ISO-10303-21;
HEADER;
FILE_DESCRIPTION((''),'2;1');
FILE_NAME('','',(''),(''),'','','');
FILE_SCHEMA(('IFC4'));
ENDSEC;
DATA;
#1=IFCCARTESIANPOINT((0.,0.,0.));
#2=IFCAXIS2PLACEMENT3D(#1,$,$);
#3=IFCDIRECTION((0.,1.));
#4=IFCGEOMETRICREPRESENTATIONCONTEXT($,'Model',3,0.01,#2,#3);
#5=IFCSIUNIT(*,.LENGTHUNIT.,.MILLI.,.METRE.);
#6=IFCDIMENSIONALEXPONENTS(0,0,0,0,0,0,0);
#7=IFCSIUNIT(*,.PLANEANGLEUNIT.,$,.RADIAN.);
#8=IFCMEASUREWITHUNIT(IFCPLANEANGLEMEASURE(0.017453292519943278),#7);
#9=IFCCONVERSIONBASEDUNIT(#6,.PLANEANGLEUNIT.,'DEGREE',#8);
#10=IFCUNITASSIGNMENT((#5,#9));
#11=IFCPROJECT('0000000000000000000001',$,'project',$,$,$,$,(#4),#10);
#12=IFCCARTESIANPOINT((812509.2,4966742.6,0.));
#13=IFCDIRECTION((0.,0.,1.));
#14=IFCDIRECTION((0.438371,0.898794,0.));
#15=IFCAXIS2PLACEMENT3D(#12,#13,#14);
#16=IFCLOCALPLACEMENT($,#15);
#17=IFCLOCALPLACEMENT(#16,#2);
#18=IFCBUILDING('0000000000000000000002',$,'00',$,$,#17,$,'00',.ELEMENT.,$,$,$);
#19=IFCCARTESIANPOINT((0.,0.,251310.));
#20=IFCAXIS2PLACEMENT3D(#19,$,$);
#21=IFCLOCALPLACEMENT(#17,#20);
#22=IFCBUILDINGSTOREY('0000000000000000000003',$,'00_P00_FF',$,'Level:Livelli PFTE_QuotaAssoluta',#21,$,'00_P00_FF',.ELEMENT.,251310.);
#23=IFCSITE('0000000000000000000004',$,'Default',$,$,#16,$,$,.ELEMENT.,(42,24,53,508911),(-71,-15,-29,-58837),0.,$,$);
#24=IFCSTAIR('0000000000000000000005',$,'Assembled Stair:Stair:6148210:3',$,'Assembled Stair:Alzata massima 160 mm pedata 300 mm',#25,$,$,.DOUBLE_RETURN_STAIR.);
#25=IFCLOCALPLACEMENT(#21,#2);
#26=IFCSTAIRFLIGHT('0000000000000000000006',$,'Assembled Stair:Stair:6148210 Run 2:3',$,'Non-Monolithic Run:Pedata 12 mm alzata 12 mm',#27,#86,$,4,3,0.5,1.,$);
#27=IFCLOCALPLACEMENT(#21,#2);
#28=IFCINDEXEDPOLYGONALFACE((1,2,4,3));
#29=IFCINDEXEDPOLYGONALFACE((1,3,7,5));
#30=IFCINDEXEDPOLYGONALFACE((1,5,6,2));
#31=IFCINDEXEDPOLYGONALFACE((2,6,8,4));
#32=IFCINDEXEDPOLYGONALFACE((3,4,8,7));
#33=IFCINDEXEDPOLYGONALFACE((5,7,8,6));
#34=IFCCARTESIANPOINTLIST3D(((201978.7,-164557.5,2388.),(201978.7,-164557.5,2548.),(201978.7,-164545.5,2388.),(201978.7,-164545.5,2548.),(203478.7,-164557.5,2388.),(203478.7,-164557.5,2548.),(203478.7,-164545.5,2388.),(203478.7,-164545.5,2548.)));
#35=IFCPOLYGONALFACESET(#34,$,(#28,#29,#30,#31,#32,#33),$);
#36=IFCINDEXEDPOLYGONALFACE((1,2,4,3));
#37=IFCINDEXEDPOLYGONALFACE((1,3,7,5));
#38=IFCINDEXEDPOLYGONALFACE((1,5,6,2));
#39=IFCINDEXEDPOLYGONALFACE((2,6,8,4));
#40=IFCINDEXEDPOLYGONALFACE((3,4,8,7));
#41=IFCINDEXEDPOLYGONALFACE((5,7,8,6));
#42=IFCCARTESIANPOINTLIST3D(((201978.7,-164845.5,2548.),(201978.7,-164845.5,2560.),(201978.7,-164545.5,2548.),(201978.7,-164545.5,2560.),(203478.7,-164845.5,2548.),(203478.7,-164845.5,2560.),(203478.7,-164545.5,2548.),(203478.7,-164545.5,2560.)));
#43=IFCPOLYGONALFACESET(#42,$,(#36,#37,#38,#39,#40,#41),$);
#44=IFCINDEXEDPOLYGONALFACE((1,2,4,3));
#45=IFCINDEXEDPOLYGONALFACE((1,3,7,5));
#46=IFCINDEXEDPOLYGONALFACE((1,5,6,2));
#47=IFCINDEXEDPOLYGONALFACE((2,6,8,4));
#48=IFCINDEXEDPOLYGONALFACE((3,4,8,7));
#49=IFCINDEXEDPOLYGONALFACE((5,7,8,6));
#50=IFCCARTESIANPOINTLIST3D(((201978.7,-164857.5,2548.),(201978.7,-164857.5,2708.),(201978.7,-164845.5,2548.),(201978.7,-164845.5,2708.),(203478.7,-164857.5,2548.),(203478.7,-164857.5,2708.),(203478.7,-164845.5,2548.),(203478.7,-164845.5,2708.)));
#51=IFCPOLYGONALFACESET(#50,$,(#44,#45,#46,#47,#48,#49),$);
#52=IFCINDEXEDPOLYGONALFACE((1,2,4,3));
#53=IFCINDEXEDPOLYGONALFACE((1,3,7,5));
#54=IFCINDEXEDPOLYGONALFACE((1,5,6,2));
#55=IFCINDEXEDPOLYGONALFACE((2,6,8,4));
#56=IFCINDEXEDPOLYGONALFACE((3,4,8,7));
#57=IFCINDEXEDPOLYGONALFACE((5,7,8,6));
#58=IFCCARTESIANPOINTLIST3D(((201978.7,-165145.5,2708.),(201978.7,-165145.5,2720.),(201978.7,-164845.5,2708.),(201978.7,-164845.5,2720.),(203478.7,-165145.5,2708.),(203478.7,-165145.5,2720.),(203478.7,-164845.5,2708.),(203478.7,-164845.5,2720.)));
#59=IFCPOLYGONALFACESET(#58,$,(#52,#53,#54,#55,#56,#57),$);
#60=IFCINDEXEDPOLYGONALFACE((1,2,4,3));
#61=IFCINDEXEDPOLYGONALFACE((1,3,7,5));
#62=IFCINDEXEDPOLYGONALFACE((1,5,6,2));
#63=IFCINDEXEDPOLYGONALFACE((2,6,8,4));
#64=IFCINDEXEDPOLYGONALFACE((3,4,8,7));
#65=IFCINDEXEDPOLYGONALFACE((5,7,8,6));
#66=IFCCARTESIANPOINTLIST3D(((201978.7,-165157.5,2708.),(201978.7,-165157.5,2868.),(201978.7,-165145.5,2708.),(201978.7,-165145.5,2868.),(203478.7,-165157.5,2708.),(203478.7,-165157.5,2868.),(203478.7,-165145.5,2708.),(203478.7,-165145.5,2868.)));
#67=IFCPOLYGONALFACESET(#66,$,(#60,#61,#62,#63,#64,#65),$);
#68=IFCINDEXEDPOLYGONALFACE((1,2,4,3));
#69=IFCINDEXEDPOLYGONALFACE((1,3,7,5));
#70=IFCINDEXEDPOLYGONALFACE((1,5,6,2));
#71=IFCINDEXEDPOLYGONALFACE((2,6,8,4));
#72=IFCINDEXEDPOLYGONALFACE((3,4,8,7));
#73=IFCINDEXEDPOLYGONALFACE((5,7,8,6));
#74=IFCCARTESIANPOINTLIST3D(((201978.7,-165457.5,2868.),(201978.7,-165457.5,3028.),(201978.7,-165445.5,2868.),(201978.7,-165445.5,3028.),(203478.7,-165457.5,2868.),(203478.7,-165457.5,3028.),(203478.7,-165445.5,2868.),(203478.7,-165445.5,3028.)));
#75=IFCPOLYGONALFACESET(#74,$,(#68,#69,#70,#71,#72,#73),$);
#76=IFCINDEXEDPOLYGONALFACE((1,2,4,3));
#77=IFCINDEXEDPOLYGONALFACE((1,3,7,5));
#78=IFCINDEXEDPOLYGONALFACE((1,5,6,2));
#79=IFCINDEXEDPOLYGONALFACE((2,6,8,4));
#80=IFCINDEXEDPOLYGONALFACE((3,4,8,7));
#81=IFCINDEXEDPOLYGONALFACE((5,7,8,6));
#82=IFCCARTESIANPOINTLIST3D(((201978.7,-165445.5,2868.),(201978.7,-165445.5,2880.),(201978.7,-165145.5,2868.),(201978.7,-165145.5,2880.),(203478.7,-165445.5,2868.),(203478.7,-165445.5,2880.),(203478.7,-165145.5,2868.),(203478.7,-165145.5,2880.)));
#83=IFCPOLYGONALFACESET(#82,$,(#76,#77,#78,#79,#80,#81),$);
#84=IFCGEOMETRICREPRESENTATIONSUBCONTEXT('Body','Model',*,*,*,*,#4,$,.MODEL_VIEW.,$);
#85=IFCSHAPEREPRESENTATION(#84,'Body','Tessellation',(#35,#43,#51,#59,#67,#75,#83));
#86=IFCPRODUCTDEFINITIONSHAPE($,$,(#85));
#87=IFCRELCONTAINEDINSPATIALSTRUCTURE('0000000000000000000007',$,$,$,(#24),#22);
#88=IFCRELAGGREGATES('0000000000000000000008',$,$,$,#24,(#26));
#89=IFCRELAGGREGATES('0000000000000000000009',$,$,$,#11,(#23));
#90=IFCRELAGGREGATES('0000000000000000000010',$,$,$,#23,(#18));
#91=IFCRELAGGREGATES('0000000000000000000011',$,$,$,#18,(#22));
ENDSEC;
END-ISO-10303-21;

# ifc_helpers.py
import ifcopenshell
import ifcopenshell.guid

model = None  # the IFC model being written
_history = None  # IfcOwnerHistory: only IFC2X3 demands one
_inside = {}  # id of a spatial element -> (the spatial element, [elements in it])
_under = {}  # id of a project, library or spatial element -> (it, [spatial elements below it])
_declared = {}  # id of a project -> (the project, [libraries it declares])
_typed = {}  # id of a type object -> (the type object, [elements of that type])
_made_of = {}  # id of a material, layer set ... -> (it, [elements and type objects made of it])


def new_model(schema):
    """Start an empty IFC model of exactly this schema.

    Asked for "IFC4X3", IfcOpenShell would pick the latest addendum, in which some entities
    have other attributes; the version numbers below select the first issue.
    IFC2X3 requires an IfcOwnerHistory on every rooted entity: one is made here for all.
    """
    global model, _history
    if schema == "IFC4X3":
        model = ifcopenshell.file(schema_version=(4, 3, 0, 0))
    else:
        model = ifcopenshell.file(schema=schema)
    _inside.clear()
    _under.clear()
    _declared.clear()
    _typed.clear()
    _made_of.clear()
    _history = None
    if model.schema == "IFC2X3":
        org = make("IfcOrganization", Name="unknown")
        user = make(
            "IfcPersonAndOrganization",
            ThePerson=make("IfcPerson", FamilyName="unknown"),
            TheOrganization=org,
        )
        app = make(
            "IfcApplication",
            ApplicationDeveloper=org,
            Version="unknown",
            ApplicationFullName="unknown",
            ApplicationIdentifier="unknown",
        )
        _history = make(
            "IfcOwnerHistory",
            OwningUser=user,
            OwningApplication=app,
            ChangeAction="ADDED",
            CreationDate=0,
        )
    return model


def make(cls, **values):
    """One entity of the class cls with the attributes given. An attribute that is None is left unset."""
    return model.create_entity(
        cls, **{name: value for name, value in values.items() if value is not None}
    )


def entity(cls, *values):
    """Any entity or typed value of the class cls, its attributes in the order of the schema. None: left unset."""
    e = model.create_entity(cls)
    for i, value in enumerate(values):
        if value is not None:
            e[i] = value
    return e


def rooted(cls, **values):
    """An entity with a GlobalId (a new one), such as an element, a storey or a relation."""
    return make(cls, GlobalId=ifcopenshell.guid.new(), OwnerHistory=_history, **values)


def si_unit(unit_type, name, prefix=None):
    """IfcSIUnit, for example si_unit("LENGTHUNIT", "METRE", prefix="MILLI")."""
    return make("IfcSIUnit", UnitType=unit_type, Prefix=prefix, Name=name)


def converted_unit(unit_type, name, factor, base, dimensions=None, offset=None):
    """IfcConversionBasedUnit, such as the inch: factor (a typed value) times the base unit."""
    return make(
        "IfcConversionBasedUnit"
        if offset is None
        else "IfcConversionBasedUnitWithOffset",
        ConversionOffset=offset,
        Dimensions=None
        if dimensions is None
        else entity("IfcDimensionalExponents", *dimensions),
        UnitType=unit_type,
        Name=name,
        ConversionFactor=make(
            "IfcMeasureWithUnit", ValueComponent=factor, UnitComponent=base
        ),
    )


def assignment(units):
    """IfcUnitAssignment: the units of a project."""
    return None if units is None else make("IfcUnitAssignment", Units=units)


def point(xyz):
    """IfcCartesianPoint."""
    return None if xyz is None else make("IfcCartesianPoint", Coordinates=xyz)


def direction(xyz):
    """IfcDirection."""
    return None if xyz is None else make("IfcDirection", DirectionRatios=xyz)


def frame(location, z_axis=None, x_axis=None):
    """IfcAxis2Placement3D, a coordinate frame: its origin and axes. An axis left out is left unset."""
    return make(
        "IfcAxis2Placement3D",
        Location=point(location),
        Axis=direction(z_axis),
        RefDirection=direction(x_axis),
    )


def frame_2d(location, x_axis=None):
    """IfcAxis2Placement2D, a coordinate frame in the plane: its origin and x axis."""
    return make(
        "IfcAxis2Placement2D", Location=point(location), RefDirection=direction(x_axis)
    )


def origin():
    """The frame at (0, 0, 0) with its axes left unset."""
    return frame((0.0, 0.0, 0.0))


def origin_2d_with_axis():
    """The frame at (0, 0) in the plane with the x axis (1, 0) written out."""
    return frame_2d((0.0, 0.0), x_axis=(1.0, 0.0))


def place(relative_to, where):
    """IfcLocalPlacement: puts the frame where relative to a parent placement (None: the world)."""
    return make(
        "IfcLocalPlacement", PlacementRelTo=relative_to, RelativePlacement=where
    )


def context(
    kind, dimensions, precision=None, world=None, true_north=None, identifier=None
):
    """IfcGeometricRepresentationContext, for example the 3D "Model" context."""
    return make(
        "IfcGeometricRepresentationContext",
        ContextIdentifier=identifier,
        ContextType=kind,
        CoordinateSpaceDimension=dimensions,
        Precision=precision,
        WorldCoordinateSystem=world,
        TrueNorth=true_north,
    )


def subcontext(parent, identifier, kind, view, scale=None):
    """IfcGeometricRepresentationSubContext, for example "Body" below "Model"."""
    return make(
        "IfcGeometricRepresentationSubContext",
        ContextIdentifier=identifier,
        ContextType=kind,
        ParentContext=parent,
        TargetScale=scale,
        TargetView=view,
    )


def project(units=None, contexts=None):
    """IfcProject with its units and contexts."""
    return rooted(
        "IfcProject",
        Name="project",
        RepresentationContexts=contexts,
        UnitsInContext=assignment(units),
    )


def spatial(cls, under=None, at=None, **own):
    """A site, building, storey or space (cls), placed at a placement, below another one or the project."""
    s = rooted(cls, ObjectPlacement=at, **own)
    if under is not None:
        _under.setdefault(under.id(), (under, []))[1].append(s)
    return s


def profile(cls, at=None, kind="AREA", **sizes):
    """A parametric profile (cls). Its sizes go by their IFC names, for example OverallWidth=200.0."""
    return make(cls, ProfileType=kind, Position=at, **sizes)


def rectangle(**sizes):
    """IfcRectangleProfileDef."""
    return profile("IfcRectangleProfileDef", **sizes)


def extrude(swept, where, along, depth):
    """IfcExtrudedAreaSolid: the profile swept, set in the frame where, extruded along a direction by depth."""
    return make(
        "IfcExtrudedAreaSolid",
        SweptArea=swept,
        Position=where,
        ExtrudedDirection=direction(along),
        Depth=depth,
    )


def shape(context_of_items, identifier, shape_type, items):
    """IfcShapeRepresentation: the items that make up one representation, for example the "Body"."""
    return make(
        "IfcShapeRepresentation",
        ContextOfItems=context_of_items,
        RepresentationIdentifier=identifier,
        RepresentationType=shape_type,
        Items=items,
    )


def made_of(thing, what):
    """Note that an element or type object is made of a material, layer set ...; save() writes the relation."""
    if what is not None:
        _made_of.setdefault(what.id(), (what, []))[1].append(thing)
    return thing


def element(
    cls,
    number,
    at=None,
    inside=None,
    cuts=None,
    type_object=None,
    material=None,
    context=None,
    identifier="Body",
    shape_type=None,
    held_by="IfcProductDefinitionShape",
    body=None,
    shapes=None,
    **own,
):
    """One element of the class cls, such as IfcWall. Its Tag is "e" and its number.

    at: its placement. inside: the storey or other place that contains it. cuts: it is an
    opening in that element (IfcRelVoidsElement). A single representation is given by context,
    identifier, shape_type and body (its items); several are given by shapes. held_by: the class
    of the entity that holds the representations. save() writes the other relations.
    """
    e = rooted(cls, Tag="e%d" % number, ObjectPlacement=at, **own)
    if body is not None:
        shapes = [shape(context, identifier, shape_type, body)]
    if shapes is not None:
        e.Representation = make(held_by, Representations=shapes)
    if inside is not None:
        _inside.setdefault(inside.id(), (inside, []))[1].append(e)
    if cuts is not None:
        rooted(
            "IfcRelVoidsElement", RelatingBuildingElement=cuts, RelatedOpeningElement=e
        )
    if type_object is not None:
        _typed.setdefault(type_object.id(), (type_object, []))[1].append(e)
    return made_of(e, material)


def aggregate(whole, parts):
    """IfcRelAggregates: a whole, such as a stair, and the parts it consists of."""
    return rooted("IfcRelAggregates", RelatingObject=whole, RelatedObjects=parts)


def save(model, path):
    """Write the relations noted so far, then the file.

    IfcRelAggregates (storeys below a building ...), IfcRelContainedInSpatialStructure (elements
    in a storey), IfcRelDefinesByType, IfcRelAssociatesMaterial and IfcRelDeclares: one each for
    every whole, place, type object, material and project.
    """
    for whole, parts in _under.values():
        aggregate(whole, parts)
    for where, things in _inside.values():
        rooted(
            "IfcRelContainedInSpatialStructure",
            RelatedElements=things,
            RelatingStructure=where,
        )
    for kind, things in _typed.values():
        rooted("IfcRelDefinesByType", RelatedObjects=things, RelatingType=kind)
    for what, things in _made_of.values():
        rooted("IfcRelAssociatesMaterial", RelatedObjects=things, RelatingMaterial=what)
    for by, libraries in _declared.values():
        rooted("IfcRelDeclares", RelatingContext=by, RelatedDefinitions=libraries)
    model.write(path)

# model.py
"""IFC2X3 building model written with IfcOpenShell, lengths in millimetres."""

from ifc_helpers import new_model, entity, si_unit, converted_unit, direction, frame, origin, origin_2d_with_axis, place, context, subcontext, project, spatial, rectangle, extrude, element, aggregate, save


model = new_model("IFC2X3")

# Units and contexts
model_context = context("Model", 3, precision=0.01, world=origin(), true_north=direction((0.0, 1.0)))
body_context = subcontext(model_context, "Body", "Model", "MODEL_VIEW")
ifc_project = project(units=[si_unit("LENGTHUNIT", "METRE", prefix="MILLI"), converted_unit("PLANEANGLEUNIT", "DEGREE", entity("IfcPlaneAngleMeasure", 0.017453292519943278), si_unit("PLANEANGLEUNIT", "RADIAN"), dimensions=[0, 0, 0, 0, 0, 0, 0])], contexts=[model_context])

# Site, building, storey
site_placement = place(None, frame((812509.2, 4966742.6, 0.0), z_axis=(0.0, 0.0, 1.0), x_axis=(0.438371, 0.898794, 0.0)))
site = spatial("IfcSite", under=ifc_project, at=site_placement, Name="Default", CompositionType="ELEMENT", RefLatitude=(42, 24, 53, 508911), RefLongitude=(-71, -15, -29, -58837), RefElevation=0.0)
building_placement = place(site_placement, origin())
building = spatial("IfcBuilding", under=site, at=building_placement, Name="00", LongName="00", CompositionType="ELEMENT")
storey_placement = place(building_placement, frame((0.0, 0.0, 251310.0)))
storey = spatial("IfcBuildingStorey", under=building, at=storey_placement, Name="00_P00_FF", ObjectType="Level:Livelli PFTE_QuotaAssoluta", LongName="00_P00_FF", CompositionType="ELEMENT", Elevation=251310.0)

# Stair
stair_1_placement = place(storey_placement, origin())
stair_1 = element("IfcStair", 1, at=stair_1_placement, inside=storey, Name="Assembled Stair:Stair:6148210:3", ObjectType="Assembled Stair:Alzata massima 160 mm pedata 300 mm", ShapeType="DOUBLE_RETURN_STAIR")

# Stair flight
stair_flight_1_placement = place(stair_1_placement, origin())
stair_flight_1 = element("IfcStairFlight", 2, at=stair_flight_1_placement, Name="Assembled Stair:Stair:6148210 Run 2:3", ObjectType="Non-Monolithic Run:Pedata 12 mm alzata 12 mm", NumberOfRiser=4, NumberOfTreads=3, RiserHeight=0.5, TreadLength=1.0, context=body_context, shape_type="SweptSolid", body=[
    extrude(rectangle(XDim=1500.0, YDim=12.0, at=origin_2d_with_axis()), frame((202728.7, -164551.5, 2388.0)), (0.0, 0.0, 1.0), 160.0),
    extrude(rectangle(XDim=300.0, YDim=1500.0, at=origin_2d_with_axis()), frame((202728.7, -164695.5, 2548.0), z_axis=(0.0, 0.0, 1.0), x_axis=(0.0, 1.0, 0.0)), (0.0, 0.0, 1.0), 12.0),
    extrude(rectangle(XDim=1500.0, YDim=12.0, at=origin_2d_with_axis()), frame((202728.7, -164851.5, 2548.0)), (0.0, 0.0, 1.0), 160.0),
    extrude(rectangle(XDim=300.0, YDim=1500.0, at=origin_2d_with_axis()), frame((202728.7, -164995.5, 2708.0), z_axis=(0.0, 0.0, 1.0), x_axis=(0.0, 1.0, 0.0)), (0.0, 0.0, 1.0), 12.0),
    extrude(rectangle(XDim=1500.0, YDim=12.0, at=origin_2d_with_axis()), frame((202728.7, -165151.5, 2708.0)), (0.0, 0.0, 1.0), 160.0),
    extrude(rectangle(XDim=1500.0, YDim=12.0, at=origin_2d_with_axis()), frame((202728.7, -165451.5, 2868.0)), (0.0, 0.0, 1.0), 160.0),
    extrude(rectangle(XDim=300.0, YDim=1500.0, at=origin_2d_with_axis()), frame((202728.7, -165295.5, 2868.0), z_axis=(0.0, 0.0, 1.0), x_axis=(0.0, 1.0, 0.0)), (0.0, 0.0, 1.0), 12.0),
])
aggregate(stair_1, [stair_flight_1])

save(model, "model.ifc")
